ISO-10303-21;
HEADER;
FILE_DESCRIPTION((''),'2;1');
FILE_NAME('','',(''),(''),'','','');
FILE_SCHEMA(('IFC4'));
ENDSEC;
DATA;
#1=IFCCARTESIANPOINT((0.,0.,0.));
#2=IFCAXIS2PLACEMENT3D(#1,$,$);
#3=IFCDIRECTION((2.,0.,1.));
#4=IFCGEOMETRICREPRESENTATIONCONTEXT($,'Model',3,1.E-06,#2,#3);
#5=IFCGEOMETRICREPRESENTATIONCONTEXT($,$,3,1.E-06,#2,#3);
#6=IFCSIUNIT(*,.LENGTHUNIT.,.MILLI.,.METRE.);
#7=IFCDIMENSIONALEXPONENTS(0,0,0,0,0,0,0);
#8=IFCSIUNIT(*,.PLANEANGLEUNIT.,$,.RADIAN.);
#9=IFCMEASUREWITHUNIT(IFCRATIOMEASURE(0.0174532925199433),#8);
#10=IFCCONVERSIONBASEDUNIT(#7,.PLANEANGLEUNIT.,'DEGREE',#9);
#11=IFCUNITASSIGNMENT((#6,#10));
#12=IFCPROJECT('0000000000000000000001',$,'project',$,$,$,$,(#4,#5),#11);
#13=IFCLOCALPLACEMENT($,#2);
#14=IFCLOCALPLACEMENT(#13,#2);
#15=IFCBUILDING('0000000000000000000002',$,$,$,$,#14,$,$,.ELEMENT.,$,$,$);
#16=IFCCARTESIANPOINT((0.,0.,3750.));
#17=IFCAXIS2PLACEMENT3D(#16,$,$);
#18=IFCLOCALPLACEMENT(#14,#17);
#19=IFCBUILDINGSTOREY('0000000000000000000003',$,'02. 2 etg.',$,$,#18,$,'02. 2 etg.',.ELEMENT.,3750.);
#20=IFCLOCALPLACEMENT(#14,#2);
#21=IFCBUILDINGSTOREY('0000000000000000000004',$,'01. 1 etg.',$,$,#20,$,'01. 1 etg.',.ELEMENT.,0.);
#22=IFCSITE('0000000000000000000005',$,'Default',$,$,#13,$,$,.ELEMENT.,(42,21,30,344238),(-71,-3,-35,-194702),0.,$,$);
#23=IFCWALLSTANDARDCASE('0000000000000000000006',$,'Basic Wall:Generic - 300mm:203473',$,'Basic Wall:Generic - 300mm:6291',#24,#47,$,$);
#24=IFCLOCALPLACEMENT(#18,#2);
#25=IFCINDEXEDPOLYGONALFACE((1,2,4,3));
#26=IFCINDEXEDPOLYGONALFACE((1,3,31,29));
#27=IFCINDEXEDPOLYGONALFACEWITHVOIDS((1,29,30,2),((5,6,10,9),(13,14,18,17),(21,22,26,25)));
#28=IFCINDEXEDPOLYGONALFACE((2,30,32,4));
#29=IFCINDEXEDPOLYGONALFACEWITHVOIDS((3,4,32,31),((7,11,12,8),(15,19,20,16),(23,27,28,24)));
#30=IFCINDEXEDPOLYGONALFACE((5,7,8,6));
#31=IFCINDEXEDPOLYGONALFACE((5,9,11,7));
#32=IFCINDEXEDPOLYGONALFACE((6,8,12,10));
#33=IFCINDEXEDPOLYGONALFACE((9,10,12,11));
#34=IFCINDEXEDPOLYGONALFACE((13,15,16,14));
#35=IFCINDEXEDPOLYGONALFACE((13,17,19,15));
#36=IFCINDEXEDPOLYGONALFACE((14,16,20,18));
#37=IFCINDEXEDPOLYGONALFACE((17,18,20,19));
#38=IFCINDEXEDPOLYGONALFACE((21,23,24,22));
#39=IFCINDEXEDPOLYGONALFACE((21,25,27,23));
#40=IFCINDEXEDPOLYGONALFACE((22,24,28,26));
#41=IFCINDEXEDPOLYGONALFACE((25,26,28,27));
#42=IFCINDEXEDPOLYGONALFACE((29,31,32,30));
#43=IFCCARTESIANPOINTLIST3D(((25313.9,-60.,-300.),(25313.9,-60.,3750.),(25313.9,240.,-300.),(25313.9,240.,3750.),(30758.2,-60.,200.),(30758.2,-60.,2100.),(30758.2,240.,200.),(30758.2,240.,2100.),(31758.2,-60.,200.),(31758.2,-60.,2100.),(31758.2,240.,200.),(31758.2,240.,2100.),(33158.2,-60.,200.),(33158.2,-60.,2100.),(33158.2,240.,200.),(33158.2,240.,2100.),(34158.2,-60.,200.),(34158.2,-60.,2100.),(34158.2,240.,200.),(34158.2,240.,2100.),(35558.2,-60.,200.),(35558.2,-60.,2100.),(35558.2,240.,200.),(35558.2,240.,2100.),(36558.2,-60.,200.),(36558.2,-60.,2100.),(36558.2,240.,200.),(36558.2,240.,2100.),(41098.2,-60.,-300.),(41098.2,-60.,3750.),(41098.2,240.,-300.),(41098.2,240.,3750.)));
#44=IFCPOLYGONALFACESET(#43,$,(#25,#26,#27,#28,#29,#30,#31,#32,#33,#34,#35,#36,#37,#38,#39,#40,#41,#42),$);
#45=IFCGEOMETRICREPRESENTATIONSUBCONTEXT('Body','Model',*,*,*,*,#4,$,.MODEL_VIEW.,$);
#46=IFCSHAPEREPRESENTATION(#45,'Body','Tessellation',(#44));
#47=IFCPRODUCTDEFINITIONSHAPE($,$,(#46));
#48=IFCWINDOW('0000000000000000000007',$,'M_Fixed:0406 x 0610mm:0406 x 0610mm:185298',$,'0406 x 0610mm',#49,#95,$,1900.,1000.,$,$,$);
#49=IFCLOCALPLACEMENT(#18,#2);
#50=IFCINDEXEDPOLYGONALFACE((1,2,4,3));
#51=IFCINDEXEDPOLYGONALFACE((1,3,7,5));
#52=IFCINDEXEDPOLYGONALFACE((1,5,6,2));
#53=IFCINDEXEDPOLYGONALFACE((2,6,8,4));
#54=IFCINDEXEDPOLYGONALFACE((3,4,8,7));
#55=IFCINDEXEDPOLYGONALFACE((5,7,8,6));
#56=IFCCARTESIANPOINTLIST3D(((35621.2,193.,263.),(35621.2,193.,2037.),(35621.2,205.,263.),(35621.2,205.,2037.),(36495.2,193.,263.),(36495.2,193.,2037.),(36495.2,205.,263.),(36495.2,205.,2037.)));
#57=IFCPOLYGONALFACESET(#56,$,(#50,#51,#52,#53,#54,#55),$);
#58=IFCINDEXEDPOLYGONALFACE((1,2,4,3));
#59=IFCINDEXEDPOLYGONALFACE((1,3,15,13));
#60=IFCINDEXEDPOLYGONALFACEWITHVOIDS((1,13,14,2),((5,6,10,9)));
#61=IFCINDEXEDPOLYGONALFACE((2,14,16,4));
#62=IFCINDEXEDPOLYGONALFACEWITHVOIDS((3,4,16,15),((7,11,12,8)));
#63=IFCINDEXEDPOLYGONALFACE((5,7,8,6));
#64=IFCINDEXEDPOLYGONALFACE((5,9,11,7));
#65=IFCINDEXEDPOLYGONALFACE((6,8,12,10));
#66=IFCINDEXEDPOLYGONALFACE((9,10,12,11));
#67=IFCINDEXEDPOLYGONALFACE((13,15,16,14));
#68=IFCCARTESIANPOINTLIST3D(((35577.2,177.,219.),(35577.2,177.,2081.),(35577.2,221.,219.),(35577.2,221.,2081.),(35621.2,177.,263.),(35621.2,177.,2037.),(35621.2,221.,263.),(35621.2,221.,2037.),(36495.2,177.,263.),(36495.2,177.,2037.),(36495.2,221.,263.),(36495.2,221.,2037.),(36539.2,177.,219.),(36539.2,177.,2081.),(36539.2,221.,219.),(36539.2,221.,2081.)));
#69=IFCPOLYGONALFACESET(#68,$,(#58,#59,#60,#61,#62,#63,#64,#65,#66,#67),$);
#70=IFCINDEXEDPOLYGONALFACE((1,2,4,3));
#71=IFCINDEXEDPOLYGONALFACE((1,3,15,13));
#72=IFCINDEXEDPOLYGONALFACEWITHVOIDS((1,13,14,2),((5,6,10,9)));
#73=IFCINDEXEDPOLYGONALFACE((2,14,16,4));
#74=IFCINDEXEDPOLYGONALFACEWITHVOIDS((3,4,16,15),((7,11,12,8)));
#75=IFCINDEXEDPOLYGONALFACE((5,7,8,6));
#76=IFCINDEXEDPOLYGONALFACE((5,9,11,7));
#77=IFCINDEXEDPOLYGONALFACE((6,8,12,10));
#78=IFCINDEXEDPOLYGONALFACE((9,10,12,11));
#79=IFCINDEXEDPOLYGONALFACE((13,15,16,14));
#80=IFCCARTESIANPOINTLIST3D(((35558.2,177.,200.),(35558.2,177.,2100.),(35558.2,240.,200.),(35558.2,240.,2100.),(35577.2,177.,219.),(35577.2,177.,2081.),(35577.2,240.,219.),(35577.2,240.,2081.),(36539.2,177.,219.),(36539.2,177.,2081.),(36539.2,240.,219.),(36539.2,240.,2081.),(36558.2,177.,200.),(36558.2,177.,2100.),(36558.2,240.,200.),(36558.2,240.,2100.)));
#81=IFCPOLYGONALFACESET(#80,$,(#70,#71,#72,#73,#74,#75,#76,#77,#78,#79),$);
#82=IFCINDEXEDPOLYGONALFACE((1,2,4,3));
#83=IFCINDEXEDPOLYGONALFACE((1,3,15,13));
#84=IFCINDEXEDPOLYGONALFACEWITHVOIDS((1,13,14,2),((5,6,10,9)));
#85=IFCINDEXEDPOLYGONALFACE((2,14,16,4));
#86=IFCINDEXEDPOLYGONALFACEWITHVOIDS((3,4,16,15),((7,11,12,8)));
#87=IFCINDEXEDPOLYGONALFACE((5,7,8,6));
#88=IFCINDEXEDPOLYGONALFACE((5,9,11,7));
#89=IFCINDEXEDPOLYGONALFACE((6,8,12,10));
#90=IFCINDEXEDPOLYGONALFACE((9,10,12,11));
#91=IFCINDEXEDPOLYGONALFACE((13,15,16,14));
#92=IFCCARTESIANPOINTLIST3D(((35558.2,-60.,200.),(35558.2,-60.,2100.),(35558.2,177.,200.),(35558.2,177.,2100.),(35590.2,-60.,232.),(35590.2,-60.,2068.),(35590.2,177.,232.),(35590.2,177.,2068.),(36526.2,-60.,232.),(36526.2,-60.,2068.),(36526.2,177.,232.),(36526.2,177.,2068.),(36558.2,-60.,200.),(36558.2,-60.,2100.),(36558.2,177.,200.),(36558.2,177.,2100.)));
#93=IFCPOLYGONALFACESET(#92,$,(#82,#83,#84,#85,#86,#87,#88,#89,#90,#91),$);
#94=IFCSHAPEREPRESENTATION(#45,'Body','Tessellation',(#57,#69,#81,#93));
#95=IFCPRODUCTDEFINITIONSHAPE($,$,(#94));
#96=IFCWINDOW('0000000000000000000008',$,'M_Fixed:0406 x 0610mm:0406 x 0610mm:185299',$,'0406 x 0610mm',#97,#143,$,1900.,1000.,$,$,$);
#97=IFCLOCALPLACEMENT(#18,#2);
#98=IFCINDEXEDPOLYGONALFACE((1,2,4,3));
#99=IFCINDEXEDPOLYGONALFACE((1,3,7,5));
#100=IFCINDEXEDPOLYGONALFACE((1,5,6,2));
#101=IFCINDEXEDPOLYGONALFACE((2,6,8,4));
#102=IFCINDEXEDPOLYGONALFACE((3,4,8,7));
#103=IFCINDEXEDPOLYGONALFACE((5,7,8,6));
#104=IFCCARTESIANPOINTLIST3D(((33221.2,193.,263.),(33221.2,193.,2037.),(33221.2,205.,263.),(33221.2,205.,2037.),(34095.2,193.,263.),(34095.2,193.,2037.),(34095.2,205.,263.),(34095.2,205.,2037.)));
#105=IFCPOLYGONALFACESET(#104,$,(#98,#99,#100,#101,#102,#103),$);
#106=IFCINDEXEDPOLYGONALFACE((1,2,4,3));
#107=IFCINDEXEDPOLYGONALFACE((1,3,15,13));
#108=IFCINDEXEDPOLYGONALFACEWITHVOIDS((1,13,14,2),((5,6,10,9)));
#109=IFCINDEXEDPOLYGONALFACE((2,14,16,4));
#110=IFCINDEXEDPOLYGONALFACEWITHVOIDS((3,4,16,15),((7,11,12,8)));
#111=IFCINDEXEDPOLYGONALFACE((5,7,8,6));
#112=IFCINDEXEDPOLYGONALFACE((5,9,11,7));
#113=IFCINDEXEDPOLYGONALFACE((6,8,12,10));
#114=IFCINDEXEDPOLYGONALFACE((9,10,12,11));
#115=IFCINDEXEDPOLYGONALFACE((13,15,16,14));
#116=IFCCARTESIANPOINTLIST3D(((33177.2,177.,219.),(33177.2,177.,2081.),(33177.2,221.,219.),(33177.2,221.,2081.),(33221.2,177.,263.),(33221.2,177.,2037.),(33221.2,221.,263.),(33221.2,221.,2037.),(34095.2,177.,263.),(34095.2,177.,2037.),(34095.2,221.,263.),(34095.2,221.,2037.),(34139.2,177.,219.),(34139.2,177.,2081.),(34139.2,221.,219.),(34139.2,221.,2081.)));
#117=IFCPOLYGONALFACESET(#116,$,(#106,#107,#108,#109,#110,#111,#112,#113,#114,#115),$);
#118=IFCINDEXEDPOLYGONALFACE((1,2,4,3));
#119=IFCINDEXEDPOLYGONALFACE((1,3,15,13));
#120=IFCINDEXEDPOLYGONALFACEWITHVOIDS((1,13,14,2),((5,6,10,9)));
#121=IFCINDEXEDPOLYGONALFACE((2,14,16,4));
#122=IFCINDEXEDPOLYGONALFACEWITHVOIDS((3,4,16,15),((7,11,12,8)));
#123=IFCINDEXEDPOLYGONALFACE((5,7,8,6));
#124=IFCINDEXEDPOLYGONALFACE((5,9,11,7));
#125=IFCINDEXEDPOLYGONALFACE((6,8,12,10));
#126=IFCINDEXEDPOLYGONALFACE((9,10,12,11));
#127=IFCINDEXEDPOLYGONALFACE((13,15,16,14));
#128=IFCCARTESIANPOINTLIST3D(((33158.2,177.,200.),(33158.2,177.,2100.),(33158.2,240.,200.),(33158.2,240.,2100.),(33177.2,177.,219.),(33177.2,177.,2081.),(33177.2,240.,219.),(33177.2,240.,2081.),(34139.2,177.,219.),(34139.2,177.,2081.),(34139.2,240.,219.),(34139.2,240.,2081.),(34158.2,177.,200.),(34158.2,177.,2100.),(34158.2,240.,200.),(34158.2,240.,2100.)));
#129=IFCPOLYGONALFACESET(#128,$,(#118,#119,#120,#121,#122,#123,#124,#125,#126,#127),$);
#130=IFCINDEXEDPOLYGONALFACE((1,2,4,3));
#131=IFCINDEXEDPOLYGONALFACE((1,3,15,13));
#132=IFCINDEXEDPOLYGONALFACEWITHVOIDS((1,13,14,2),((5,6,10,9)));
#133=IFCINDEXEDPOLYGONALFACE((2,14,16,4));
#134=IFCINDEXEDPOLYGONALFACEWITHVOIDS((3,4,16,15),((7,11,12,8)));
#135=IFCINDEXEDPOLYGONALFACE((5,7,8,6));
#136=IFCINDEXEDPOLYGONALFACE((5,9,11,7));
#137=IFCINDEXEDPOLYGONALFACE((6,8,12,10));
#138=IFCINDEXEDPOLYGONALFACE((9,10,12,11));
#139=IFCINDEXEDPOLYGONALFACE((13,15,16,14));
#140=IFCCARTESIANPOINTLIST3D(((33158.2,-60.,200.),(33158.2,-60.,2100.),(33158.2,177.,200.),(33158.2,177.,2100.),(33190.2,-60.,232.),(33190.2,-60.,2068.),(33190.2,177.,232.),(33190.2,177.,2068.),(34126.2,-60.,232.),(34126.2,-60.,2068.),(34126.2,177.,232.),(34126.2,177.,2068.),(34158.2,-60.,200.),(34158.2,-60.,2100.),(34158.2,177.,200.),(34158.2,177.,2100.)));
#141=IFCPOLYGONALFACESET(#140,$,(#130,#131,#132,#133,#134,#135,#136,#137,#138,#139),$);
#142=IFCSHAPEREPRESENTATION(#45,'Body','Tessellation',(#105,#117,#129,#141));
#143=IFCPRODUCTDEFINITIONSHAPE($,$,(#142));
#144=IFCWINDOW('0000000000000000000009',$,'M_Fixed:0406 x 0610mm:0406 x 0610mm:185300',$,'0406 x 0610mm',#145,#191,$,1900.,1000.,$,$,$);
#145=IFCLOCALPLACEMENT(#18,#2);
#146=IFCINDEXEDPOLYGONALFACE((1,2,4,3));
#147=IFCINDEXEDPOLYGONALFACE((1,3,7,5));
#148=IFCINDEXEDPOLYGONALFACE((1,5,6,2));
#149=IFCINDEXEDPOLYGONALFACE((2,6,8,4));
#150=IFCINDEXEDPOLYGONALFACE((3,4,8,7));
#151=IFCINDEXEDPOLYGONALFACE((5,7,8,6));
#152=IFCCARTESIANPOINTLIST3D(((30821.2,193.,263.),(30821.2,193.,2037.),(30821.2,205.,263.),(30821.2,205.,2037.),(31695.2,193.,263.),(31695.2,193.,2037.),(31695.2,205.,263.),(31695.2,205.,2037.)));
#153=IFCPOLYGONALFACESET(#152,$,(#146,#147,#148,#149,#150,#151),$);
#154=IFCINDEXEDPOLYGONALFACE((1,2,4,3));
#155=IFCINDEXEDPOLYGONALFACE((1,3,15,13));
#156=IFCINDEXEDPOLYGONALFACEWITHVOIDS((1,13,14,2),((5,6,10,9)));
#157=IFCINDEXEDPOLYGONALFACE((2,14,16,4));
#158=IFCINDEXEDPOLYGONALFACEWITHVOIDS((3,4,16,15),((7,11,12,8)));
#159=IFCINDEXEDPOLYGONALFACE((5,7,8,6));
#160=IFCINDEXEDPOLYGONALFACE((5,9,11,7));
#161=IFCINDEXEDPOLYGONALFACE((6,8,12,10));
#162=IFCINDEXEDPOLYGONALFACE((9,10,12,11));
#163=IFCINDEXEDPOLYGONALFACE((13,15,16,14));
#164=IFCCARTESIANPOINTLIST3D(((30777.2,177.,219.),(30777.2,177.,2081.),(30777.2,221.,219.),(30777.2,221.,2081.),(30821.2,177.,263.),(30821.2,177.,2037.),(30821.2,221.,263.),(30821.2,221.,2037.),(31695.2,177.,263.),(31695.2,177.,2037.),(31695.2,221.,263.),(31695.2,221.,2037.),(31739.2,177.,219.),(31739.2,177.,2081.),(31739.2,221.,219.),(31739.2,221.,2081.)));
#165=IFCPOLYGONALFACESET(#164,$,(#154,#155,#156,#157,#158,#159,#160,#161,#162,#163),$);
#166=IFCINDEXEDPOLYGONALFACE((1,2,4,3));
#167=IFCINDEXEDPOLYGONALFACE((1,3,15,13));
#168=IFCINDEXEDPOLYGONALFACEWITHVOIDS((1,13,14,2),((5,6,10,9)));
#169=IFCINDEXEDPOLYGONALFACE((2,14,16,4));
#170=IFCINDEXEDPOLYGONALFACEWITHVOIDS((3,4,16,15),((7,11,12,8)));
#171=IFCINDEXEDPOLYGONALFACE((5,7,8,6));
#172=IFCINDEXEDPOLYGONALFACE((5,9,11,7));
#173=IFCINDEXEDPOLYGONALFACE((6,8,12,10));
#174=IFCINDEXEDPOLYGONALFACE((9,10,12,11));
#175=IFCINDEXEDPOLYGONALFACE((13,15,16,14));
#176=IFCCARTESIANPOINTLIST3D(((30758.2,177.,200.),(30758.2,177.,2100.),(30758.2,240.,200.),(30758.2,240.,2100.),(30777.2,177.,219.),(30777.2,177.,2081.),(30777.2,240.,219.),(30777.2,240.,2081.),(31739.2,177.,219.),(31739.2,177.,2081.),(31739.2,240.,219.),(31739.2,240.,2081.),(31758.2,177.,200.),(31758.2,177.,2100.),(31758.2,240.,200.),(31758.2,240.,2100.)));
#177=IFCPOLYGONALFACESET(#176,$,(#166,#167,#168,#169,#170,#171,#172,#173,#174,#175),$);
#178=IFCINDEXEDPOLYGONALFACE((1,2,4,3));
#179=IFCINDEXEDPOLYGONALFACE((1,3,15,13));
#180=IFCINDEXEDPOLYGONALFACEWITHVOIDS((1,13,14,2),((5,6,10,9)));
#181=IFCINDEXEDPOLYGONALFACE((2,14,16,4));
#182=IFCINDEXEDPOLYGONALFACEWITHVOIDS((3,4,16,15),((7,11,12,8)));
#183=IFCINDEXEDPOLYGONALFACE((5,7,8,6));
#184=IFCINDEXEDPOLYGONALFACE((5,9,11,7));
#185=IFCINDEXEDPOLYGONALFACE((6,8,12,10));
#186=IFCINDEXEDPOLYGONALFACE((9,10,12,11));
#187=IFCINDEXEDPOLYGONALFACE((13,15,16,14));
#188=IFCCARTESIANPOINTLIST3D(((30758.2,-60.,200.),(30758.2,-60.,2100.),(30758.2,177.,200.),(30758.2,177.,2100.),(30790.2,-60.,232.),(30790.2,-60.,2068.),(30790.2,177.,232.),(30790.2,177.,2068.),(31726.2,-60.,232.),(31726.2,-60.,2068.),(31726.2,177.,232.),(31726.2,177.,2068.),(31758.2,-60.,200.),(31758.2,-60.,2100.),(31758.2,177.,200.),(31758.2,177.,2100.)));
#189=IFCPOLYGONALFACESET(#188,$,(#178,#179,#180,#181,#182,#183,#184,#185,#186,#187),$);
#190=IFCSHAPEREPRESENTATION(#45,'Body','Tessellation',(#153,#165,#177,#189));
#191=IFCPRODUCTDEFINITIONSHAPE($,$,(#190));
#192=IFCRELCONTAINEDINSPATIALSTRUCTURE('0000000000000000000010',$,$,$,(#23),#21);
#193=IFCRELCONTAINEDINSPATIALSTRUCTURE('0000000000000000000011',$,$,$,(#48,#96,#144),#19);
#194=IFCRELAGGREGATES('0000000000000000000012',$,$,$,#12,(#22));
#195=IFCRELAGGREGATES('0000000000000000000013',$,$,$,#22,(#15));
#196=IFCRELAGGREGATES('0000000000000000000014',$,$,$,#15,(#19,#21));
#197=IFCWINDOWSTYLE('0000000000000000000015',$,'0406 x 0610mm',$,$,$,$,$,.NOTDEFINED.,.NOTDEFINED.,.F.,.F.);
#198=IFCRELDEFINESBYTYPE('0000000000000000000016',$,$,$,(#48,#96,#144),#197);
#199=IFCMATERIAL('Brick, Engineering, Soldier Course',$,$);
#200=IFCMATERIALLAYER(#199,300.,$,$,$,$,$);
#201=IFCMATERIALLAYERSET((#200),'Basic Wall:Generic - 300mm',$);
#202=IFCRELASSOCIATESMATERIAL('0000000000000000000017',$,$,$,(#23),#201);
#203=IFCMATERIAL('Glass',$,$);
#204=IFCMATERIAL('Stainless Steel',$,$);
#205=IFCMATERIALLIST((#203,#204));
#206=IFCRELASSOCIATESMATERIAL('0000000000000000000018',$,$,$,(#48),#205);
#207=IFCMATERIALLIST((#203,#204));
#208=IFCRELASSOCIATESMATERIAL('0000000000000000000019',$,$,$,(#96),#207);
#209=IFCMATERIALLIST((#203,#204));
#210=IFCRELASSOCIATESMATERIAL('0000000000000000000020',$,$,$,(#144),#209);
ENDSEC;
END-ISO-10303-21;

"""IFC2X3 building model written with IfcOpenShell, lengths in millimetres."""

from ifc_helpers import new_model, entity, si_unit, converted_unit, direction, frame, frame_2d, origin, place, context, subcontext, project, spatial, polyline, rectangle, outline, extrude, source, transform, mapped, material, material_list, layer, layer_set, layer_usage, type_object, type_shapes, element, fill, save


model = new_model("IFC2X3")

# Units and contexts
model_context = context("Model", 3, precision=1e-06, world=origin(), true_north=direction((2.0, 0.0, 1.0)))
context_of_model = context(None, 3, precision=1e-06, world=origin(), true_north=direction((2.0, 0.0, 1.0)))
body_context = subcontext(model_context, "Body", "Model", "MODEL_VIEW")
ifc_project = project(units=[si_unit("LENGTHUNIT", "METRE", prefix="MILLI"), converted_unit("PLANEANGLEUNIT", "DEGREE", entity("IfcRatioMeasure", 0.0174532925199433), si_unit("PLANEANGLEUNIT", "RADIAN"), dimensions=[0, 0, 0, 0, 0, 0, 0])], contexts=[model_context, context_of_model])

# Site, building, storey
site_placement = place(None, origin())
site = spatial("IfcSite", under=ifc_project, at=site_placement, Name="Default", CompositionType="ELEMENT", RefLatitude=(42, 21, 30, 344238), RefLongitude=(-71, -3, -35, -194702), RefElevation=0.0)
building_placement = place(site_placement, origin())
building = spatial("IfcBuilding", under=site, at=building_placement, CompositionType="ELEMENT")
storey_1_placement = place(building_placement, frame((0.0, 0.0, 3750.0)))
storey_1 = spatial("IfcBuildingStorey", under=building, at=storey_1_placement, Name="02. 2 etg.", LongName="02. 2 etg.", CompositionType="ELEMENT", Elevation=3750.0)

# Shared definitions
ifc_material_1 = material(Name="Glass")
storey_2_placement = place(building_placement, origin())

# Shared definitions
ifc_material_2 = material(Name="Stainless Steel")

# Shared definitions
ifc_material_3 = material(Name="Brick, Engineering, Soldier Course")
ifc_layer_1 = layer(ifc_material_3, 300.0)
ifc_layer_set_1 = layer_set([ifc_layer_1], Name="Basic Wall:Generic - 300mm")

# Shared definitions
storey_2 = spatial("IfcBuildingStorey", under=building, at=storey_2_placement, Name="01. 1 etg.", LongName="01. 1 etg.", CompositionType="ELEMENT", Elevation=0.0)

# Wall, openings, windows
ifc_layer_usage_1 = layer_usage(ifc_layer_set_1, "AXIS2", "NEGATIVE", 150.0)
wall_1_placement = place(storey_2_placement, frame((25313.9, 90.0, 3450.0)))
wall_1 = element("IfcWallStandardCase", 1, at=wall_1_placement, inside=storey_2, material=ifc_layer_usage_1, Name="Basic Wall:Generic - 300mm:203473", ObjectType="Basic Wall:Generic - 300mm:6291", context=body_context, shape_type="SweptSolid", body=[
    extrude(rectangle(XDim=15784.3, YDim=300.0, at=frame_2d((7892.2, 0.0), x_axis=(-1.0, 0.0))), origin(), (0.0, 0.0, 1.0), 4050.0),
])
opening_1_placement = place(wall_1_placement, frame((10244.3, -150.0, 500.0)))
opening_1 = element("IfcOpeningElement", 2, at=opening_1_placement, cuts=wall_1, ObjectType="Opening", context=body_context, shape_type="SweptSolid", body=[
    extrude(rectangle(XDim=1900.0, YDim=1000.0, at=frame_2d((950.0, 500.0), x_axis=(1.0, 0.0))), frame((0.0, 0.0, 0.0), z_axis=(0.0, 1.0, 0.0), x_axis=(0.0, 0.0, 1.0)), (0.0, 0.0, 1.0), 300.0),
])
opening_2_placement = place(wall_1_placement, frame((7844.3, -150.0, 500.0)))
opening_2 = element("IfcOpeningElement", 3, at=opening_2_placement, cuts=wall_1, ObjectType="Opening", context=body_context, shape_type="SweptSolid", body=[
    extrude(rectangle(XDim=1900.0, YDim=1000.0, at=frame_2d((950.0, 500.0), x_axis=(1.0, 0.0))), frame((0.0, 0.0, 0.0), z_axis=(0.0, 1.0, 0.0), x_axis=(0.0, 0.0, 1.0)), (0.0, 0.0, 1.0), 300.0),
])
opening_3_placement = place(wall_1_placement, frame((5444.3, -150.0, 500.0)))
opening_3 = element("IfcOpeningElement", 4, at=opening_3_placement, cuts=wall_1, ObjectType="Opening", context=body_context, shape_type="SweptSolid", body=[
    extrude(rectangle(XDim=1900.0, YDim=1000.0, at=frame_2d((950.0, 500.0), x_axis=(1.0, 0.0))), frame((0.0, 0.0, 0.0), z_axis=(0.0, 1.0, 0.0), x_axis=(0.0, 0.0, 1.0)), (0.0, 0.0, 1.0), 300.0),
])
ifc_material_list_1 = material_list([ifc_material_1, ifc_material_2])
window_style = type_object("IfcWindowStyle", Name="0406 x 0610mm", ConstructionType="NOTDEFINED", OperationType="NOTDEFINED", ParameterTakesPrecedence=False, Sizeable=False)
shared_shape_1 = source(origin(), body_context, "Body", "SweptSolid", [
    extrude(rectangle(XDim=874.0, YDim=12.0, at=frame_2d((0.0, 0.0), x_axis=(1.0, 0.0))), frame((500.0, 285.0, 63.0), z_axis=(0.0, 0.0, 1.0), x_axis=(-1.0, 0.0, 0.0)), (0.0, 0.0, 1.0), 1774.0),
    extrude(outline(polyline([(-481.0, -931.0), (481.0, -931.0), (481.0, 931.0), (-481.0, 931.0), (-481.0, -931.0)]), holes=[polyline([(-437.0, -887.0), (-437.0, 887.0), (437.0, 887.0), (437.0, -887.0), (-437.0, -887.0)])]), frame((500.0, 307.0, 950.0), z_axis=(0.0, -1.0, 0.0), x_axis=(-1.0, 0.0, 0.0)), (0.0, 0.0, 1.0), 44.0),
    extrude(outline(polyline([(-500.0, -950.0), (500.0, -950.0), (500.0, 950.0), (-500.0, 950.0), (-500.0, -950.0)]), holes=[polyline([(-481.0, -931.0), (-481.0, 931.0), (481.0, 931.0), (481.0, -931.0), (-481.0, -931.0)])]), frame((500.0, 326.0, 950.0), z_axis=(0.0, -1.0, 0.0), x_axis=(-1.0, 0.0, 0.0)), (0.0, 0.0, 1.0), 63.0),
    extrude(outline(polyline([(-500.0, -950.0), (500.0, -950.0), (500.0, 950.0), (-500.0, 950.0), (-500.0, -950.0)]), holes=[polyline([(-468.0, -918.0), (-468.0, 918.0), (468.0, 918.0), (468.0, -918.0), (-468.0, -918.0)])]), frame((500.0, 263.0, 950.0), z_axis=(0.0, -1.0, 0.0), x_axis=(-1.0, 0.0, 0.0)), (0.0, 0.0, 1.0), 237.0),
])
type_shapes(window_style, [shared_shape_1])
window_1_placement = place(opening_1_placement, frame((0.0, -26.0, 0.0)))
window_1 = element("IfcWindow", 5, at=window_1_placement, inside=storey_1, type_object=window_style, material=ifc_material_list_1, Name="M_Fixed:0406 x 0610mm:0406 x 0610mm:185298", ObjectType="0406 x 0610mm", OverallHeight=1900.0, OverallWidth=1000.0, context=body_context, shape_type="MappedRepresentation", body=[
    mapped(shared_shape_1, transform((0.0, 0.0, 0.0), scale=1.0)),
])
fill(opening_1, window_1)
ifc_material_list_2 = material_list([ifc_material_1, ifc_material_2])
window_2_placement = place(opening_2_placement, frame((0.0, -26.0, 0.0)))
window_2 = element("IfcWindow", 6, at=window_2_placement, inside=storey_1, type_object=window_style, material=ifc_material_list_2, Name="M_Fixed:0406 x 0610mm:0406 x 0610mm:185299", ObjectType="0406 x 0610mm", OverallHeight=1900.0, OverallWidth=1000.0, context=body_context, shape_type="MappedRepresentation", body=[
    mapped(shared_shape_1, transform((0.0, 0.0, 0.0), scale=1.0)),
])
fill(opening_2, window_2)
ifc_material_list_3 = material_list([ifc_material_1, ifc_material_2])
window_3_placement = place(opening_3_placement, frame((0.0, -26.0, 0.0)))
window_3 = element("IfcWindow", 7, at=window_3_placement, inside=storey_1, type_object=window_style, material=ifc_material_list_3, Name="M_Fixed:0406 x 0610mm:0406 x 0610mm:185300", ObjectType="0406 x 0610mm", OverallHeight=1900.0, OverallWidth=1000.0, context=body_context, shape_type="MappedRepresentation", body=[
    mapped(shared_shape_1, transform((0.0, 0.0, 0.0), scale=1.0)),
])
fill(opening_3, window_3)

save(model, "model.ifc")
